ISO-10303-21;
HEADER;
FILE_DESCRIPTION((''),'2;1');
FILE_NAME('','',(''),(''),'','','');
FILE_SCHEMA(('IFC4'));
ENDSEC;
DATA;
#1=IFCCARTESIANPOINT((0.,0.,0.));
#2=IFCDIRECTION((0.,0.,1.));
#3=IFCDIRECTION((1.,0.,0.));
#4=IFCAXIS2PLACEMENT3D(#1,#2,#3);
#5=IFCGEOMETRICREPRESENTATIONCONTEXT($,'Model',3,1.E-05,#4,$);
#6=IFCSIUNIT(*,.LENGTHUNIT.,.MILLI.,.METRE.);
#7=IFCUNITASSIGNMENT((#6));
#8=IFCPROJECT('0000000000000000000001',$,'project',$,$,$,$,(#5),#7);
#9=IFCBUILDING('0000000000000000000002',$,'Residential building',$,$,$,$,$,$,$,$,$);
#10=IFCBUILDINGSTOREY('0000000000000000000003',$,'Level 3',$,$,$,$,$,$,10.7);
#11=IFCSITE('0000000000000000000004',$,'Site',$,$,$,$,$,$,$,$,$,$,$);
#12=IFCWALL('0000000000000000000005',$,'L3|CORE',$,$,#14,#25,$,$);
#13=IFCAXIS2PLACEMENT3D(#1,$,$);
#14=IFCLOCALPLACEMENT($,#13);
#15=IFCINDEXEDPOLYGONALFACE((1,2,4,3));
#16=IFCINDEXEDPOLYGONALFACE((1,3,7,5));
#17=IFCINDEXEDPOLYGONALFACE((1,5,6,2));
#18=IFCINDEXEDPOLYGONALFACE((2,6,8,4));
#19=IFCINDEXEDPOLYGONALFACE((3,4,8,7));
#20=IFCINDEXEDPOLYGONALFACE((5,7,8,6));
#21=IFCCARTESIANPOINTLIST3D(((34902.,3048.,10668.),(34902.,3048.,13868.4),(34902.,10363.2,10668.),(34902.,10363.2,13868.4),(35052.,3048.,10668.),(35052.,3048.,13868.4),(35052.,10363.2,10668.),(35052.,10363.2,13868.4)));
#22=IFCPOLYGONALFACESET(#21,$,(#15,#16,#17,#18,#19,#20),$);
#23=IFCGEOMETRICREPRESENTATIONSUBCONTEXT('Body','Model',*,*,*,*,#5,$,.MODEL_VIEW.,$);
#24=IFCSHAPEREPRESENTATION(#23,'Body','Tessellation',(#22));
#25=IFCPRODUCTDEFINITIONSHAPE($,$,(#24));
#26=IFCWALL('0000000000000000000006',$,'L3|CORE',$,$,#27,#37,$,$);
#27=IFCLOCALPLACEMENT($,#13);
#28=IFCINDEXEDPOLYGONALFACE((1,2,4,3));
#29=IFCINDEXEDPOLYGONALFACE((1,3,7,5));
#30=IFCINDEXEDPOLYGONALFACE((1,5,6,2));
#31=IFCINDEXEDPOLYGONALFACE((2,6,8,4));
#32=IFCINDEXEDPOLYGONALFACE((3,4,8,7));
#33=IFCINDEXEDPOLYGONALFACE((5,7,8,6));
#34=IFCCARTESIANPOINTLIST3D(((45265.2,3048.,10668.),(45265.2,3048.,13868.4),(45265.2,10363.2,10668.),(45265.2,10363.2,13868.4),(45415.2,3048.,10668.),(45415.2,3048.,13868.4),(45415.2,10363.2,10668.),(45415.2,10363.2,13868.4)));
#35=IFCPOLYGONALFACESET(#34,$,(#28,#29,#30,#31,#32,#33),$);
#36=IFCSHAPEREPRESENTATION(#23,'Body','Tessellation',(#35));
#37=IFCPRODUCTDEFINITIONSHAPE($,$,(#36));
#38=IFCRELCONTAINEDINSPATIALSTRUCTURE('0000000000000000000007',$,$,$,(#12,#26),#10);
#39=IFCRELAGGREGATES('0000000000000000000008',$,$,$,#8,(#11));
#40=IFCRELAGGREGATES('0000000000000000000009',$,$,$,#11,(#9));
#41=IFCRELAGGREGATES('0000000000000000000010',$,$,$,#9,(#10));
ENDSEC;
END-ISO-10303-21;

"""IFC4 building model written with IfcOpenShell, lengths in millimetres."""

from ifc_helpers import new_model, si_unit, frame, origin_with_axes, place, context, subcontext, project, spatial, indexed_curve, outline, extrude, element, save


model = new_model("IFC4")

# Units and contexts
model_context = context("Model", 3, precision=1e-05, world=origin_with_axes())
body_context = subcontext(model_context, "Body", "Model", "MODEL_VIEW")
ifc_project = project(units=[si_unit("LENGTHUNIT", "METRE", prefix="MILLI")], contexts=[model_context])

# Site, building, storey
site = spatial("IfcSite", under=ifc_project, Name="Site")
building = spatial("IfcBuilding", under=site, Name="Residential building")
storey = spatial("IfcBuildingStorey", under=building, Name="Level 3", Elevation=10.7)

# Walls
for number, where, z_axis, x_axis, name in (
    (1, (35052.0, 3048.0, 10668.0), (0.0, 0.0, 1.0), (0.0, 1.0, 0.0), "L3|CORE"),
    (2, (45415.2, 3048.0, 10668.0), (0.0, 0.0, 1.0), (0.0, 1.0, 0.0), "L3|CORE"),
):
    element("IfcWall", number, at=place(None, frame(where, z_axis=z_axis, x_axis=x_axis)), inside=storey, Name=name, context=body_context, shape_type="SweptSolid", body=[
        extrude(outline(indexed_curve([(0.0, 0.0), (0.0, 150.0), (7315.2, 150.0), (7315.2, 0.0), (0.0, 0.0)], self_intersect=False)), origin_with_axes(), (0.0, 0.0, 1.0), 3200.4),
    ])

save(model, "model.ifc")
